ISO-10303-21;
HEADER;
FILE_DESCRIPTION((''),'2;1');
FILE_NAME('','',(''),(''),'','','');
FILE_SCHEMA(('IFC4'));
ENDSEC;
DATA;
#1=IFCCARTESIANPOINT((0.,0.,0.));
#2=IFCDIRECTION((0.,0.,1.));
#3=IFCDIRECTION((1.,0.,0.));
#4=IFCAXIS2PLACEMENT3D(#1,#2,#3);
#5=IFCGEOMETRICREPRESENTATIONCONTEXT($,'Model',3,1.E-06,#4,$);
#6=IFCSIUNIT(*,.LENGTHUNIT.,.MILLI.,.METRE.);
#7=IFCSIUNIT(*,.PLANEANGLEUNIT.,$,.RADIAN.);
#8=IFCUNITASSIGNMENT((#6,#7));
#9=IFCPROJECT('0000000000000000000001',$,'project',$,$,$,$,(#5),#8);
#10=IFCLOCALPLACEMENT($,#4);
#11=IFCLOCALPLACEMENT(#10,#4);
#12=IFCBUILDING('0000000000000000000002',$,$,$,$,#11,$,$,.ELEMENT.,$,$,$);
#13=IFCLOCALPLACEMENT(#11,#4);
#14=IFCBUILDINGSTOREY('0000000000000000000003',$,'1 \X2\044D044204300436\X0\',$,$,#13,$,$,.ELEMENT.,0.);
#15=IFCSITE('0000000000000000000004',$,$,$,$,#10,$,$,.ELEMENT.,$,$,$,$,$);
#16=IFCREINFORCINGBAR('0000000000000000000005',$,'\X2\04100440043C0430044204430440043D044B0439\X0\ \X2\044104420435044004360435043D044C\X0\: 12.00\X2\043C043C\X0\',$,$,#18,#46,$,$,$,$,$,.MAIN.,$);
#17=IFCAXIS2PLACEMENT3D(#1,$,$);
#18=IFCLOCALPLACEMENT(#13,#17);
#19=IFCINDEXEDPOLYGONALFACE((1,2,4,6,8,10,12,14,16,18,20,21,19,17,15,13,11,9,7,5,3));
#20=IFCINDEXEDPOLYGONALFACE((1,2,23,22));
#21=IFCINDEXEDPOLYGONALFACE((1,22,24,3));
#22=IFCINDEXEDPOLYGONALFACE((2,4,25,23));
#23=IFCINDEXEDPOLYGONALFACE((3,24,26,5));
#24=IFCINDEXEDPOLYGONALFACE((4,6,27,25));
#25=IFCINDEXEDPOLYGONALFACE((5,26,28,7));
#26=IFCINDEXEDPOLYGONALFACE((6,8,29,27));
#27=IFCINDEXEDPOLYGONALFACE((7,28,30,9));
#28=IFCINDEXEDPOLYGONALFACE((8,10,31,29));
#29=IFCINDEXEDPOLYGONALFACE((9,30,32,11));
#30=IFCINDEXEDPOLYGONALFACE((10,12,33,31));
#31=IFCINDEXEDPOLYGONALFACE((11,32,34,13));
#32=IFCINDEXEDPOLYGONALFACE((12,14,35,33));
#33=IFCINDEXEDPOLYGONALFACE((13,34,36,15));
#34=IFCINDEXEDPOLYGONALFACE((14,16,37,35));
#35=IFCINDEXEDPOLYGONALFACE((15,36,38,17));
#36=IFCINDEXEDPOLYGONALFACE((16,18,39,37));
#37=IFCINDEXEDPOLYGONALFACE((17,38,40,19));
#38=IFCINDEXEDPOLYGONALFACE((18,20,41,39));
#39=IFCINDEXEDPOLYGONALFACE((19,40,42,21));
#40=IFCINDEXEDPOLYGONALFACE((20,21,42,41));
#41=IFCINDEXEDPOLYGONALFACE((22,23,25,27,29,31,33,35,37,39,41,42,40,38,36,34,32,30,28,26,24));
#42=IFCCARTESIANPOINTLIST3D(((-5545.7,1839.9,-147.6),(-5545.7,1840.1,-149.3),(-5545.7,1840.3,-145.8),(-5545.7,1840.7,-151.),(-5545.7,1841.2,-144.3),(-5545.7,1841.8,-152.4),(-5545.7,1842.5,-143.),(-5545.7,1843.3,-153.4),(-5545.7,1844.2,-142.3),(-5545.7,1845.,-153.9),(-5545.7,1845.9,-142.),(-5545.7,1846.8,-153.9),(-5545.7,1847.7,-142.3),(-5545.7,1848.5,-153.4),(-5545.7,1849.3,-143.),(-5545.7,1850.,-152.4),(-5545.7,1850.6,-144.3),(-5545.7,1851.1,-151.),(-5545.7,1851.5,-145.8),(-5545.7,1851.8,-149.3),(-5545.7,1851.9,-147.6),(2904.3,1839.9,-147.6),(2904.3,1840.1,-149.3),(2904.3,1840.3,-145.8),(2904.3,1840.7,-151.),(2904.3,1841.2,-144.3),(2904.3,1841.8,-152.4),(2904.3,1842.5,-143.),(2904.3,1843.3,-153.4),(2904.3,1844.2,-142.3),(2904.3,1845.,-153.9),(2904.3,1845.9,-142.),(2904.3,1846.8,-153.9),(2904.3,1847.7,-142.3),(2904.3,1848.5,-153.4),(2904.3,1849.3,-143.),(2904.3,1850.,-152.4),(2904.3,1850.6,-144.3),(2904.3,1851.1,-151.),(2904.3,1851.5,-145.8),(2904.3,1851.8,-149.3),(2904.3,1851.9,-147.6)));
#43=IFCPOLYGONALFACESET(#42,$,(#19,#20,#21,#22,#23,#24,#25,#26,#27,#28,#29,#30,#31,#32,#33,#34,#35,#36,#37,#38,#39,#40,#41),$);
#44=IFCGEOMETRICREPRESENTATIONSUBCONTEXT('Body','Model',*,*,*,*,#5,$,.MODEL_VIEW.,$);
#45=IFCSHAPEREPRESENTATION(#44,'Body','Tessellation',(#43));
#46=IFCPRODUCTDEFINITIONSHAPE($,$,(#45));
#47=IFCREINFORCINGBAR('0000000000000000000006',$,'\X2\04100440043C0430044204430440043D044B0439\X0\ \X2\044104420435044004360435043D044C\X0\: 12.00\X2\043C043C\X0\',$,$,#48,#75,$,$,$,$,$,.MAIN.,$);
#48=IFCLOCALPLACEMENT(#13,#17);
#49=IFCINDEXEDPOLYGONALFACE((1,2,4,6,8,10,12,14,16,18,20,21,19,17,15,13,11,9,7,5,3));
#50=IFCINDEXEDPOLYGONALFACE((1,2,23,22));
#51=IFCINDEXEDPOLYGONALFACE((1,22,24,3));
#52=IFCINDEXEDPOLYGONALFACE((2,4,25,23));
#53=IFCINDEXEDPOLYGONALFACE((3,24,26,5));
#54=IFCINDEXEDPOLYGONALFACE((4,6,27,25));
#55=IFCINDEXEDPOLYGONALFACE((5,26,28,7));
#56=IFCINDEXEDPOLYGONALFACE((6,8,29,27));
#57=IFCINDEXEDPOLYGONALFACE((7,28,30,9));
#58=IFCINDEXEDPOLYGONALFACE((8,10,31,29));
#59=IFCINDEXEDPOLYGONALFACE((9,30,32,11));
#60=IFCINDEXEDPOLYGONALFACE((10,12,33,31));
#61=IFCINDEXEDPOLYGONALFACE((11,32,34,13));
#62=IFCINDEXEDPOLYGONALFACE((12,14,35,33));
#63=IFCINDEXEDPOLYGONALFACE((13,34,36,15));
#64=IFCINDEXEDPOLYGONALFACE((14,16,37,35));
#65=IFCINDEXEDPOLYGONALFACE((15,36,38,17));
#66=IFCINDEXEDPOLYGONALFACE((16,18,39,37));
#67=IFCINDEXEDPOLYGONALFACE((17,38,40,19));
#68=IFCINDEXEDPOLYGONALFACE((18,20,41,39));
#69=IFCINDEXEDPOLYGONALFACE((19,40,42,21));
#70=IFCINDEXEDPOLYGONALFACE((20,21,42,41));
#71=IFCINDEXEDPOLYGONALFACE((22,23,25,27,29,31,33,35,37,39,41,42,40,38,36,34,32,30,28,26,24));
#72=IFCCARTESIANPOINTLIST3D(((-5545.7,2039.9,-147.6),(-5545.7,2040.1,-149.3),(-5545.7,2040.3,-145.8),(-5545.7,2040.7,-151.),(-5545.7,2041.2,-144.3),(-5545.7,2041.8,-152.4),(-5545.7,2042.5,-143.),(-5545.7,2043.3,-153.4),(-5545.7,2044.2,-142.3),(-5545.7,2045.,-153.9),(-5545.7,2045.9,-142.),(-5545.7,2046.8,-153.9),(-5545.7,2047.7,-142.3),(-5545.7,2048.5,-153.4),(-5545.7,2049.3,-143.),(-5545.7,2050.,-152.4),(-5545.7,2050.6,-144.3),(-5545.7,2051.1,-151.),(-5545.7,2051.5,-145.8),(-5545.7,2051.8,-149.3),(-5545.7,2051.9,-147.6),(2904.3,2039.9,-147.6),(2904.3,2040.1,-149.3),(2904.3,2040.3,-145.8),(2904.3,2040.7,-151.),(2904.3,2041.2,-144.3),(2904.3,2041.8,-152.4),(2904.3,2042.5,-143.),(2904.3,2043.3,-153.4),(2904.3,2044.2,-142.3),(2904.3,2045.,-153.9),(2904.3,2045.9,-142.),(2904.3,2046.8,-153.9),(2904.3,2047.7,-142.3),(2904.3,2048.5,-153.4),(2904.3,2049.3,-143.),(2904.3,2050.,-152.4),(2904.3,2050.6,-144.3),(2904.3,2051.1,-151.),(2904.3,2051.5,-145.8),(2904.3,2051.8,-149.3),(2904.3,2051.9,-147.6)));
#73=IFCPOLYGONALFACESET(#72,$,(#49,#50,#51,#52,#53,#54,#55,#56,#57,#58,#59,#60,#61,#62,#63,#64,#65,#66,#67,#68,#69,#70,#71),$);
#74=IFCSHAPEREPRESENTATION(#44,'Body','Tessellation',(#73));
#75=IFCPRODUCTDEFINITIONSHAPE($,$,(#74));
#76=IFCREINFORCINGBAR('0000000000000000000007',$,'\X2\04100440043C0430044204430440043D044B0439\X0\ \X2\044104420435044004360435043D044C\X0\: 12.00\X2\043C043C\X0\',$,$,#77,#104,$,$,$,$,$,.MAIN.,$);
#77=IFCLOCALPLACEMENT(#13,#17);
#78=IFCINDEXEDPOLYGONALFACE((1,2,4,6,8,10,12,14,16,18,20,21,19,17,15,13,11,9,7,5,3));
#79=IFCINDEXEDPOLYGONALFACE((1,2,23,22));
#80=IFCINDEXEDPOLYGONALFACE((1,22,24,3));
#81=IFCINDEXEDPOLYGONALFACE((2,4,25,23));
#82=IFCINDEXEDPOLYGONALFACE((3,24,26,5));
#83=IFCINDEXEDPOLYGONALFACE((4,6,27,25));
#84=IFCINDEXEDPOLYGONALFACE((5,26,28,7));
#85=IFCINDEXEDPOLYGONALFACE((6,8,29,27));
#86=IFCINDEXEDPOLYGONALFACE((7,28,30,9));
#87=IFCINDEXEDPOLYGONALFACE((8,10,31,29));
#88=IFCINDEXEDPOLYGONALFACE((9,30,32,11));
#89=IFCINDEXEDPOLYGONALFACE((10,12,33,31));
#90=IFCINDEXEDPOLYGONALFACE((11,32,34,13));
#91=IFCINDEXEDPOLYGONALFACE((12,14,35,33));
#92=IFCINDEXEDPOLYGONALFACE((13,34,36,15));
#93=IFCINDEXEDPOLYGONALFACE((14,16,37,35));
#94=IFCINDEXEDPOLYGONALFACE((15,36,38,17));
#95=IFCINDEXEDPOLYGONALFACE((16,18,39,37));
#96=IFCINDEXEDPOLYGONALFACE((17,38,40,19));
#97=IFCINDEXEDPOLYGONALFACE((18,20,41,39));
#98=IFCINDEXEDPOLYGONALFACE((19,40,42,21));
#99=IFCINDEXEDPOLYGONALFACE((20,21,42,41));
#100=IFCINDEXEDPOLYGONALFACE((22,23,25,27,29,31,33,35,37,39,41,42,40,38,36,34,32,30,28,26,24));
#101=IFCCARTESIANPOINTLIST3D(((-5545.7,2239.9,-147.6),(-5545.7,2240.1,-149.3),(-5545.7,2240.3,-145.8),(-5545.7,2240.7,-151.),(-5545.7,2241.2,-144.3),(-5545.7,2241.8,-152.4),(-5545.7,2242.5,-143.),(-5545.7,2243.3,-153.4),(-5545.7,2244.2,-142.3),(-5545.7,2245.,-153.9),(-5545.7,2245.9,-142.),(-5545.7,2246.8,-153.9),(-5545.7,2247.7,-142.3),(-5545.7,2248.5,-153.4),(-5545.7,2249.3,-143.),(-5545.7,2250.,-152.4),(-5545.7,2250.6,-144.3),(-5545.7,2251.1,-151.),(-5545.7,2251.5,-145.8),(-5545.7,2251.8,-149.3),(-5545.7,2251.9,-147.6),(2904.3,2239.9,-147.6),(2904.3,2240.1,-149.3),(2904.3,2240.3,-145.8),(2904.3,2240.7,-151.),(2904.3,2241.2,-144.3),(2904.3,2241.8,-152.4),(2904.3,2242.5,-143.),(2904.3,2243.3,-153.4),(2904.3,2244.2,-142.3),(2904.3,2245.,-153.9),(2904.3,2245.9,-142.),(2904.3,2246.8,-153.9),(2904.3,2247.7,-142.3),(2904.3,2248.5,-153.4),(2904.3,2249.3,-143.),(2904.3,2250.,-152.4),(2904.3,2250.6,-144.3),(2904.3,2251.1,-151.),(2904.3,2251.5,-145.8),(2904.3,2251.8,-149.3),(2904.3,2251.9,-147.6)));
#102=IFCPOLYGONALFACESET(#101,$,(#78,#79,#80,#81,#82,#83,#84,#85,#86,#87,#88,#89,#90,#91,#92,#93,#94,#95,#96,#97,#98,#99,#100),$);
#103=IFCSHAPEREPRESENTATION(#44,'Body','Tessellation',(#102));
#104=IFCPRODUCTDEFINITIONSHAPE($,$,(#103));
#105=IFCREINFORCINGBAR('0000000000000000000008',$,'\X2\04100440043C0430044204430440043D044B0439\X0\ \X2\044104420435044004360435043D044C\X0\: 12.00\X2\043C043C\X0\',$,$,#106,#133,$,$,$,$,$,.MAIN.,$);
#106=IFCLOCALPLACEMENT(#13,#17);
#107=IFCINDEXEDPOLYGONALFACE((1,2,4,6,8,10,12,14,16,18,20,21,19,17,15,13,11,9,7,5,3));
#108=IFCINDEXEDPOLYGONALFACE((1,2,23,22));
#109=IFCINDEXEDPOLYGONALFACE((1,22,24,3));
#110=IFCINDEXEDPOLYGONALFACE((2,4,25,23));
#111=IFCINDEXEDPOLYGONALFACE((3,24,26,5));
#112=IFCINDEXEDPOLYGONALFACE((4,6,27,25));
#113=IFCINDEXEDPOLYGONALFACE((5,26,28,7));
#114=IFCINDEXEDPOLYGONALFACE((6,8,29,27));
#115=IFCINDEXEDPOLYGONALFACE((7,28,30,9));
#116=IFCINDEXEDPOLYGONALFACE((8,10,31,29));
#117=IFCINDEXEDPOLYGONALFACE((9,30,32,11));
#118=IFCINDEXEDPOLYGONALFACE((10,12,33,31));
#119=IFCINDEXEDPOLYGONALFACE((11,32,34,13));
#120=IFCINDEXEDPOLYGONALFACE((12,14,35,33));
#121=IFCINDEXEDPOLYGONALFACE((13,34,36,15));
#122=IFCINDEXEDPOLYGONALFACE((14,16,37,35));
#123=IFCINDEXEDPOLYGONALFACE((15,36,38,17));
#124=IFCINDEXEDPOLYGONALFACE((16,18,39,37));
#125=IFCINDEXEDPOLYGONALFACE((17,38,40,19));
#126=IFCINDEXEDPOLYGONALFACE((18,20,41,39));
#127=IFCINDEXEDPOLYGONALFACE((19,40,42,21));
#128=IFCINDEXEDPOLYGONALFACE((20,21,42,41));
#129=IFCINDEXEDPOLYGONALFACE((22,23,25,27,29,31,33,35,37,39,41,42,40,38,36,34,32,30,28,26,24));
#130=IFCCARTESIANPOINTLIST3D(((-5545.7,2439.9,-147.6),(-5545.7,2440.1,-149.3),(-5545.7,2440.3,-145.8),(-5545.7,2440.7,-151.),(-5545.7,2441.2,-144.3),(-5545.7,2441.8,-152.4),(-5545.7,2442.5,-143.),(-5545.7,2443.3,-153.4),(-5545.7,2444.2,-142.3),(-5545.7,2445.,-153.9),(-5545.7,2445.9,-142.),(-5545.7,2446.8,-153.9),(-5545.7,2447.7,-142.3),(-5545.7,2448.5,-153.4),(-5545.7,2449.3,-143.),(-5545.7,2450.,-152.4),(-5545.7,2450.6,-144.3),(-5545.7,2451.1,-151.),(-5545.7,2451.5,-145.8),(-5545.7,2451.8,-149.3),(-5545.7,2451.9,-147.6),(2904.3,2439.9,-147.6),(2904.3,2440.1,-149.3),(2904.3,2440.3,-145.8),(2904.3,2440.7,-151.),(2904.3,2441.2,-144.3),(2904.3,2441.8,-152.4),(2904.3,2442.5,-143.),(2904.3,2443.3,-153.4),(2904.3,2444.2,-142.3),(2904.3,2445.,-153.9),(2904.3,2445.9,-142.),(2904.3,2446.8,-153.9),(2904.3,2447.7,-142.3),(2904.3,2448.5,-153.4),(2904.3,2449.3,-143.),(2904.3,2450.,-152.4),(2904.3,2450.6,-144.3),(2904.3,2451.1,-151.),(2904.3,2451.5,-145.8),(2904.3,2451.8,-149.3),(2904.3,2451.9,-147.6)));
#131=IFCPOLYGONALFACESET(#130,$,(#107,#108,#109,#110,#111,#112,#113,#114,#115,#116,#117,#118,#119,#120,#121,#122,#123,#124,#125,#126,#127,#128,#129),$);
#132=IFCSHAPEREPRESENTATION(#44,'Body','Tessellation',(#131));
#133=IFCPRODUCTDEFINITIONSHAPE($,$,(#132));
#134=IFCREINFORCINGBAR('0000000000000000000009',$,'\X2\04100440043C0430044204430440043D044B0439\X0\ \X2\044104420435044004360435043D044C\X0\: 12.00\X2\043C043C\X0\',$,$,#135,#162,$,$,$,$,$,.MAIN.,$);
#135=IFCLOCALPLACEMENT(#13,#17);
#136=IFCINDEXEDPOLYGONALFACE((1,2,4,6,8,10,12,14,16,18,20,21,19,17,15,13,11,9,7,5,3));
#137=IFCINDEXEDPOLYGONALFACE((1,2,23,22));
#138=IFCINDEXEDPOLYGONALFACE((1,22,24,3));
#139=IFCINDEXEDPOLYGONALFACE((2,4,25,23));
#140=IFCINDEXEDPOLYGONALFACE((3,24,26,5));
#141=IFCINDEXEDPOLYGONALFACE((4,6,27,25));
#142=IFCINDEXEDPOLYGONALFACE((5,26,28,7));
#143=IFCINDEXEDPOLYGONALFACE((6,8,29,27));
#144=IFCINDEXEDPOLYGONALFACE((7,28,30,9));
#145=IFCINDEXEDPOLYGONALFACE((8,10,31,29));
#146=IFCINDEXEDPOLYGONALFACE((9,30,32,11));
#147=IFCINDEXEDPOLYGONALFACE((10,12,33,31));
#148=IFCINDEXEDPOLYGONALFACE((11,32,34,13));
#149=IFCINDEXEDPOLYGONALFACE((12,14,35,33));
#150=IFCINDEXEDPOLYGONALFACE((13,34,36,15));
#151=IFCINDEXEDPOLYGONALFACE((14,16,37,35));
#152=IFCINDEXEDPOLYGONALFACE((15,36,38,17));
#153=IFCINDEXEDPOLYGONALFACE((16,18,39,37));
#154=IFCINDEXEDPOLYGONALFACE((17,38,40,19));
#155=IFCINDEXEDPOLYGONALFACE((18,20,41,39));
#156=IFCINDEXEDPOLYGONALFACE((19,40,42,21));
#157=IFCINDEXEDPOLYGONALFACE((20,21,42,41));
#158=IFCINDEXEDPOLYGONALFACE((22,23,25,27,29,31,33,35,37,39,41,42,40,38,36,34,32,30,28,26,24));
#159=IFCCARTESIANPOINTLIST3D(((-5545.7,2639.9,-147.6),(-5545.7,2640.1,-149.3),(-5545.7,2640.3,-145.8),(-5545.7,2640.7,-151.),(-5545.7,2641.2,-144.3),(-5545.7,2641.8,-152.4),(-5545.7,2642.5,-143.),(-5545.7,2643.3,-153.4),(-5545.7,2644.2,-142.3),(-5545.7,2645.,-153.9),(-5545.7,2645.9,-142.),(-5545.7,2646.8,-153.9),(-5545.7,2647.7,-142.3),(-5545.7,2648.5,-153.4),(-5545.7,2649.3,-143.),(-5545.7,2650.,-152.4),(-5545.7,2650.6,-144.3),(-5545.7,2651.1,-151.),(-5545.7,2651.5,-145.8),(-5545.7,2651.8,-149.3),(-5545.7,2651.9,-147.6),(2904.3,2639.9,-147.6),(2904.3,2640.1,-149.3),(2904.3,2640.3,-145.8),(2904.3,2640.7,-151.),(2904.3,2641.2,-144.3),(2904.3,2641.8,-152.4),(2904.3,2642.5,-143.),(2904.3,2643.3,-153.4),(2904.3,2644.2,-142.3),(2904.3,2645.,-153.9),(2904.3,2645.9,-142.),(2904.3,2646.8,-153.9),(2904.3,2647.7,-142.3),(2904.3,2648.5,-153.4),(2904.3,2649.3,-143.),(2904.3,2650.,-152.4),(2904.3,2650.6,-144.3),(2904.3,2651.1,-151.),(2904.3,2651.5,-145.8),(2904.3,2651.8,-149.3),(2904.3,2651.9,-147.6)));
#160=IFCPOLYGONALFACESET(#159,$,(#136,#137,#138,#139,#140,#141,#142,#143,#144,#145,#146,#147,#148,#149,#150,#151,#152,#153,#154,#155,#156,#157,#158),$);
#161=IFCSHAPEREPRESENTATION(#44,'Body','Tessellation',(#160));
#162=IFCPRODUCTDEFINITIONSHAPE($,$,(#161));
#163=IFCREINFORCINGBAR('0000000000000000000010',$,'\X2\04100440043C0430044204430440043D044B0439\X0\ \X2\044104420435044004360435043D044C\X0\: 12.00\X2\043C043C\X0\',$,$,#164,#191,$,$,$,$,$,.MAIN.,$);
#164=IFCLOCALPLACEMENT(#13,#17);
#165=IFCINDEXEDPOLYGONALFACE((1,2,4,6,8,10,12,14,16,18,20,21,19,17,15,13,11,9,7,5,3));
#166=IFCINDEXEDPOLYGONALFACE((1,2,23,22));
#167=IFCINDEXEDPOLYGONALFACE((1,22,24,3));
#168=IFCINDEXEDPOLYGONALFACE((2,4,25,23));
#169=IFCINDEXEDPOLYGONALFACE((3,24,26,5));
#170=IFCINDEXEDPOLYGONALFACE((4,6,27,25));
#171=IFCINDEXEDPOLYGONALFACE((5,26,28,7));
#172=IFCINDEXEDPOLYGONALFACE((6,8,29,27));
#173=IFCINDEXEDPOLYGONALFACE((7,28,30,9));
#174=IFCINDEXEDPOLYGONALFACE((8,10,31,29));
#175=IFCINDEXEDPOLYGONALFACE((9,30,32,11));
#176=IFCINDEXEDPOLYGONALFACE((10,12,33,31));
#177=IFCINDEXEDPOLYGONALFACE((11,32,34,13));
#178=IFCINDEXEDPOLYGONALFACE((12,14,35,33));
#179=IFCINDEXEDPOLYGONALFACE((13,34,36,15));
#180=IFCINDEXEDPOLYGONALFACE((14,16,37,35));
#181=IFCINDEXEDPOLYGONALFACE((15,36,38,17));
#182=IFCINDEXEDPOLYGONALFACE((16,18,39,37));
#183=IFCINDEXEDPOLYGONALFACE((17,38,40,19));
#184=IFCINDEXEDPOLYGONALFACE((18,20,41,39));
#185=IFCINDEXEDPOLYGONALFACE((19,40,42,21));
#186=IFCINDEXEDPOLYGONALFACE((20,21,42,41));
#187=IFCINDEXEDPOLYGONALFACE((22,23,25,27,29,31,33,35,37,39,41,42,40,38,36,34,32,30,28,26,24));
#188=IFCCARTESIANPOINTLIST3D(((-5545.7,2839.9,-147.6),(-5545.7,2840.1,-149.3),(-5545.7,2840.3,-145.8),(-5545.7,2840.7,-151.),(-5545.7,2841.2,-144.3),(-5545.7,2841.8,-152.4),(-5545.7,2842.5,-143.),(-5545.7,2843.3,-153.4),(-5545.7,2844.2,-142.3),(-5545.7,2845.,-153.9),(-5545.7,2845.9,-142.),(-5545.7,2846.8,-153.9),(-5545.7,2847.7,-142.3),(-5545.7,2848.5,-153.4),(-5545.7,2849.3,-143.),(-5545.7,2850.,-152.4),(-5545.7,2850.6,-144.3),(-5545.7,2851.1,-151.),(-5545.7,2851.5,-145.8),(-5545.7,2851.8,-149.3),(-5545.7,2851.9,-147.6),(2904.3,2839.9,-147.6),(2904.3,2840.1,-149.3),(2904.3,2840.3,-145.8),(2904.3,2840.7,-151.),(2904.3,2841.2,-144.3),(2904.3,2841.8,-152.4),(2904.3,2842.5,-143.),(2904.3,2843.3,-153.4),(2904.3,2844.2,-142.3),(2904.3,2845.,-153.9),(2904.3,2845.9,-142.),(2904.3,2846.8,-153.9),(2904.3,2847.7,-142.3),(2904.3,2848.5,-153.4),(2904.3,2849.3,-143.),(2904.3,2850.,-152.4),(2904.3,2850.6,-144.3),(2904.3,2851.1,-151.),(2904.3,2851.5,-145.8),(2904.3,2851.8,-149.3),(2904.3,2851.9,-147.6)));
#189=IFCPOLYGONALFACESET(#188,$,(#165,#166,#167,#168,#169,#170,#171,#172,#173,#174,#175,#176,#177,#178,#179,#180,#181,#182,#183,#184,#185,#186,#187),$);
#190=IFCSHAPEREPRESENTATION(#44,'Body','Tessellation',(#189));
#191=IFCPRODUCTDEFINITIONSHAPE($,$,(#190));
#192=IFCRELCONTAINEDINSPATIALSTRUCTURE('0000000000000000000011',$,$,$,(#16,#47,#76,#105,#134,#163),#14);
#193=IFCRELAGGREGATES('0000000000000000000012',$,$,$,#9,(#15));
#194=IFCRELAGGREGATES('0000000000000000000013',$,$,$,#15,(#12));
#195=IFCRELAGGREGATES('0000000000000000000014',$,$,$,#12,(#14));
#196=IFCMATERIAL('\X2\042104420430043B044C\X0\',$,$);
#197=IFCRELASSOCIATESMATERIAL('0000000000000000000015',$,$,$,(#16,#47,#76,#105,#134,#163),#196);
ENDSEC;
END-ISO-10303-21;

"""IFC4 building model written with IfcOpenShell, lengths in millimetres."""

from ifc_helpers import new_model, entity, si_unit, origin_with_axes, place, context, subcontext, project, spatial, source, transform, mapped, material, element, save


model = new_model("IFC4")

# Units and contexts
model_context = context("Model", 3, precision=1e-06, world=origin_with_axes())
body_context = subcontext(model_context, "Body", "Model", "MODEL_VIEW")
ifc_project = project(units=[si_unit("LENGTHUNIT", "METRE", prefix="MILLI"), si_unit("PLANEANGLEUNIT", "RADIAN")], contexts=[model_context])

# Site, building, storey
site_placement = place(None, origin_with_axes())
site = spatial("IfcSite", under=ifc_project, at=site_placement, CompositionType="ELEMENT")
building_placement = place(site_placement, origin_with_axes())
building = spatial("IfcBuilding", under=site, at=building_placement, CompositionType="ELEMENT")
storey_placement = place(building_placement, origin_with_axes())
storey = spatial("IfcBuildingStorey", under=building, at=storey_placement, Name="1 этаж", CompositionType="ELEMENT", Elevation=0.0)

# Reinforcing bars
ifc_material = material(Name="Сталь")
shared_shape = source(origin_with_axes(), body_context, "Body", "AdvancedSweptSolid", [
    entity("IfcSweptDiskSolid", entity("IfcIndexedPolyCurve", entity("IfcCartesianPointList3D", [[0.0, 0.0, 0.0], [8450.0, 0.0, 0.0]]), [entity("IfcLineIndex", [1, 2])]), 6.0),
])
reinforcing_bar_1_placement = place(storey_placement, origin_with_axes())
element("IfcReinforcingBar", 1, at=reinforcing_bar_1_placement, inside=storey, material=ifc_material, Name="Арматурный стержень: 12.00мм", PredefinedType="MAIN", context=body_context, shape_type="MappedRepresentation", body=[
    mapped(shared_shape, transform((-5545.7, 1845.9, -148.0), x_axis=(1.0, 0.0, 0.0), y_axis=(0.0, 1.0, 0.0), z_axis=(0.0, 0.0, 1.0), scale=1.0)),
])
reinforcing_bar_2_placement = place(storey_placement, origin_with_axes())
element("IfcReinforcingBar", 2, at=reinforcing_bar_2_placement, inside=storey, material=ifc_material, Name="Арматурный стержень: 12.00мм", PredefinedType="MAIN", context=body_context, shape_type="MappedRepresentation", body=[
    mapped(shared_shape, transform((-5545.7, 2045.9, -148.0), x_axis=(1.0, 0.0, 0.0), y_axis=(0.0, 1.0, 0.0), z_axis=(0.0, 0.0, 1.0), scale=1.0)),
])
reinforcing_bar_3_placement = place(storey_placement, origin_with_axes())
element("IfcReinforcingBar", 3, at=reinforcing_bar_3_placement, inside=storey, material=ifc_material, Name="Арматурный стержень: 12.00мм", PredefinedType="MAIN", context=body_context, shape_type="MappedRepresentation", body=[
    mapped(shared_shape, transform((-5545.7, 2245.9, -148.0), x_axis=(1.0, 0.0, 0.0), y_axis=(0.0, 1.0, 0.0), z_axis=(0.0, 0.0, 1.0), scale=1.0)),
])
reinforcing_bar_4_placement = place(storey_placement, origin_with_axes())
element("IfcReinforcingBar", 4, at=reinforcing_bar_4_placement, inside=storey, material=ifc_material, Name="Арматурный стержень: 12.00мм", PredefinedType="MAIN", context=body_context, shape_type="MappedRepresentation", body=[
    mapped(shared_shape, transform((-5545.7, 2445.9, -148.0), x_axis=(1.0, 0.0, 0.0), y_axis=(0.0, 1.0, 0.0), z_axis=(0.0, 0.0, 1.0), scale=1.0)),
])
reinforcing_bar_5_placement = place(storey_placement, origin_with_axes())
element("IfcReinforcingBar", 5, at=reinforcing_bar_5_placement, inside=storey, material=ifc_material, Name="Арматурный стержень: 12.00мм", PredefinedType="MAIN", context=body_context, shape_type="MappedRepresentation", body=[
    mapped(shared_shape, transform((-5545.7, 2645.9, -148.0), x_axis=(1.0, 0.0, 0.0), y_axis=(0.0, 1.0, 0.0), z_axis=(0.0, 0.0, 1.0), scale=1.0)),
])
reinforcing_bar_6_placement = place(storey_placement, origin_with_axes())
element("IfcReinforcingBar", 6, at=reinforcing_bar_6_placement, inside=storey, material=ifc_material, Name="Арматурный стержень: 12.00мм", PredefinedType="MAIN", context=body_context, shape_type="MappedRepresentation", body=[
    mapped(shared_shape, transform((-5545.7, 2845.9, -148.0), x_axis=(1.0, 0.0, 0.0), y_axis=(0.0, 1.0, 0.0), z_axis=(0.0, 0.0, 1.0), scale=1.0)),
])

save(model, "model.ifc")
